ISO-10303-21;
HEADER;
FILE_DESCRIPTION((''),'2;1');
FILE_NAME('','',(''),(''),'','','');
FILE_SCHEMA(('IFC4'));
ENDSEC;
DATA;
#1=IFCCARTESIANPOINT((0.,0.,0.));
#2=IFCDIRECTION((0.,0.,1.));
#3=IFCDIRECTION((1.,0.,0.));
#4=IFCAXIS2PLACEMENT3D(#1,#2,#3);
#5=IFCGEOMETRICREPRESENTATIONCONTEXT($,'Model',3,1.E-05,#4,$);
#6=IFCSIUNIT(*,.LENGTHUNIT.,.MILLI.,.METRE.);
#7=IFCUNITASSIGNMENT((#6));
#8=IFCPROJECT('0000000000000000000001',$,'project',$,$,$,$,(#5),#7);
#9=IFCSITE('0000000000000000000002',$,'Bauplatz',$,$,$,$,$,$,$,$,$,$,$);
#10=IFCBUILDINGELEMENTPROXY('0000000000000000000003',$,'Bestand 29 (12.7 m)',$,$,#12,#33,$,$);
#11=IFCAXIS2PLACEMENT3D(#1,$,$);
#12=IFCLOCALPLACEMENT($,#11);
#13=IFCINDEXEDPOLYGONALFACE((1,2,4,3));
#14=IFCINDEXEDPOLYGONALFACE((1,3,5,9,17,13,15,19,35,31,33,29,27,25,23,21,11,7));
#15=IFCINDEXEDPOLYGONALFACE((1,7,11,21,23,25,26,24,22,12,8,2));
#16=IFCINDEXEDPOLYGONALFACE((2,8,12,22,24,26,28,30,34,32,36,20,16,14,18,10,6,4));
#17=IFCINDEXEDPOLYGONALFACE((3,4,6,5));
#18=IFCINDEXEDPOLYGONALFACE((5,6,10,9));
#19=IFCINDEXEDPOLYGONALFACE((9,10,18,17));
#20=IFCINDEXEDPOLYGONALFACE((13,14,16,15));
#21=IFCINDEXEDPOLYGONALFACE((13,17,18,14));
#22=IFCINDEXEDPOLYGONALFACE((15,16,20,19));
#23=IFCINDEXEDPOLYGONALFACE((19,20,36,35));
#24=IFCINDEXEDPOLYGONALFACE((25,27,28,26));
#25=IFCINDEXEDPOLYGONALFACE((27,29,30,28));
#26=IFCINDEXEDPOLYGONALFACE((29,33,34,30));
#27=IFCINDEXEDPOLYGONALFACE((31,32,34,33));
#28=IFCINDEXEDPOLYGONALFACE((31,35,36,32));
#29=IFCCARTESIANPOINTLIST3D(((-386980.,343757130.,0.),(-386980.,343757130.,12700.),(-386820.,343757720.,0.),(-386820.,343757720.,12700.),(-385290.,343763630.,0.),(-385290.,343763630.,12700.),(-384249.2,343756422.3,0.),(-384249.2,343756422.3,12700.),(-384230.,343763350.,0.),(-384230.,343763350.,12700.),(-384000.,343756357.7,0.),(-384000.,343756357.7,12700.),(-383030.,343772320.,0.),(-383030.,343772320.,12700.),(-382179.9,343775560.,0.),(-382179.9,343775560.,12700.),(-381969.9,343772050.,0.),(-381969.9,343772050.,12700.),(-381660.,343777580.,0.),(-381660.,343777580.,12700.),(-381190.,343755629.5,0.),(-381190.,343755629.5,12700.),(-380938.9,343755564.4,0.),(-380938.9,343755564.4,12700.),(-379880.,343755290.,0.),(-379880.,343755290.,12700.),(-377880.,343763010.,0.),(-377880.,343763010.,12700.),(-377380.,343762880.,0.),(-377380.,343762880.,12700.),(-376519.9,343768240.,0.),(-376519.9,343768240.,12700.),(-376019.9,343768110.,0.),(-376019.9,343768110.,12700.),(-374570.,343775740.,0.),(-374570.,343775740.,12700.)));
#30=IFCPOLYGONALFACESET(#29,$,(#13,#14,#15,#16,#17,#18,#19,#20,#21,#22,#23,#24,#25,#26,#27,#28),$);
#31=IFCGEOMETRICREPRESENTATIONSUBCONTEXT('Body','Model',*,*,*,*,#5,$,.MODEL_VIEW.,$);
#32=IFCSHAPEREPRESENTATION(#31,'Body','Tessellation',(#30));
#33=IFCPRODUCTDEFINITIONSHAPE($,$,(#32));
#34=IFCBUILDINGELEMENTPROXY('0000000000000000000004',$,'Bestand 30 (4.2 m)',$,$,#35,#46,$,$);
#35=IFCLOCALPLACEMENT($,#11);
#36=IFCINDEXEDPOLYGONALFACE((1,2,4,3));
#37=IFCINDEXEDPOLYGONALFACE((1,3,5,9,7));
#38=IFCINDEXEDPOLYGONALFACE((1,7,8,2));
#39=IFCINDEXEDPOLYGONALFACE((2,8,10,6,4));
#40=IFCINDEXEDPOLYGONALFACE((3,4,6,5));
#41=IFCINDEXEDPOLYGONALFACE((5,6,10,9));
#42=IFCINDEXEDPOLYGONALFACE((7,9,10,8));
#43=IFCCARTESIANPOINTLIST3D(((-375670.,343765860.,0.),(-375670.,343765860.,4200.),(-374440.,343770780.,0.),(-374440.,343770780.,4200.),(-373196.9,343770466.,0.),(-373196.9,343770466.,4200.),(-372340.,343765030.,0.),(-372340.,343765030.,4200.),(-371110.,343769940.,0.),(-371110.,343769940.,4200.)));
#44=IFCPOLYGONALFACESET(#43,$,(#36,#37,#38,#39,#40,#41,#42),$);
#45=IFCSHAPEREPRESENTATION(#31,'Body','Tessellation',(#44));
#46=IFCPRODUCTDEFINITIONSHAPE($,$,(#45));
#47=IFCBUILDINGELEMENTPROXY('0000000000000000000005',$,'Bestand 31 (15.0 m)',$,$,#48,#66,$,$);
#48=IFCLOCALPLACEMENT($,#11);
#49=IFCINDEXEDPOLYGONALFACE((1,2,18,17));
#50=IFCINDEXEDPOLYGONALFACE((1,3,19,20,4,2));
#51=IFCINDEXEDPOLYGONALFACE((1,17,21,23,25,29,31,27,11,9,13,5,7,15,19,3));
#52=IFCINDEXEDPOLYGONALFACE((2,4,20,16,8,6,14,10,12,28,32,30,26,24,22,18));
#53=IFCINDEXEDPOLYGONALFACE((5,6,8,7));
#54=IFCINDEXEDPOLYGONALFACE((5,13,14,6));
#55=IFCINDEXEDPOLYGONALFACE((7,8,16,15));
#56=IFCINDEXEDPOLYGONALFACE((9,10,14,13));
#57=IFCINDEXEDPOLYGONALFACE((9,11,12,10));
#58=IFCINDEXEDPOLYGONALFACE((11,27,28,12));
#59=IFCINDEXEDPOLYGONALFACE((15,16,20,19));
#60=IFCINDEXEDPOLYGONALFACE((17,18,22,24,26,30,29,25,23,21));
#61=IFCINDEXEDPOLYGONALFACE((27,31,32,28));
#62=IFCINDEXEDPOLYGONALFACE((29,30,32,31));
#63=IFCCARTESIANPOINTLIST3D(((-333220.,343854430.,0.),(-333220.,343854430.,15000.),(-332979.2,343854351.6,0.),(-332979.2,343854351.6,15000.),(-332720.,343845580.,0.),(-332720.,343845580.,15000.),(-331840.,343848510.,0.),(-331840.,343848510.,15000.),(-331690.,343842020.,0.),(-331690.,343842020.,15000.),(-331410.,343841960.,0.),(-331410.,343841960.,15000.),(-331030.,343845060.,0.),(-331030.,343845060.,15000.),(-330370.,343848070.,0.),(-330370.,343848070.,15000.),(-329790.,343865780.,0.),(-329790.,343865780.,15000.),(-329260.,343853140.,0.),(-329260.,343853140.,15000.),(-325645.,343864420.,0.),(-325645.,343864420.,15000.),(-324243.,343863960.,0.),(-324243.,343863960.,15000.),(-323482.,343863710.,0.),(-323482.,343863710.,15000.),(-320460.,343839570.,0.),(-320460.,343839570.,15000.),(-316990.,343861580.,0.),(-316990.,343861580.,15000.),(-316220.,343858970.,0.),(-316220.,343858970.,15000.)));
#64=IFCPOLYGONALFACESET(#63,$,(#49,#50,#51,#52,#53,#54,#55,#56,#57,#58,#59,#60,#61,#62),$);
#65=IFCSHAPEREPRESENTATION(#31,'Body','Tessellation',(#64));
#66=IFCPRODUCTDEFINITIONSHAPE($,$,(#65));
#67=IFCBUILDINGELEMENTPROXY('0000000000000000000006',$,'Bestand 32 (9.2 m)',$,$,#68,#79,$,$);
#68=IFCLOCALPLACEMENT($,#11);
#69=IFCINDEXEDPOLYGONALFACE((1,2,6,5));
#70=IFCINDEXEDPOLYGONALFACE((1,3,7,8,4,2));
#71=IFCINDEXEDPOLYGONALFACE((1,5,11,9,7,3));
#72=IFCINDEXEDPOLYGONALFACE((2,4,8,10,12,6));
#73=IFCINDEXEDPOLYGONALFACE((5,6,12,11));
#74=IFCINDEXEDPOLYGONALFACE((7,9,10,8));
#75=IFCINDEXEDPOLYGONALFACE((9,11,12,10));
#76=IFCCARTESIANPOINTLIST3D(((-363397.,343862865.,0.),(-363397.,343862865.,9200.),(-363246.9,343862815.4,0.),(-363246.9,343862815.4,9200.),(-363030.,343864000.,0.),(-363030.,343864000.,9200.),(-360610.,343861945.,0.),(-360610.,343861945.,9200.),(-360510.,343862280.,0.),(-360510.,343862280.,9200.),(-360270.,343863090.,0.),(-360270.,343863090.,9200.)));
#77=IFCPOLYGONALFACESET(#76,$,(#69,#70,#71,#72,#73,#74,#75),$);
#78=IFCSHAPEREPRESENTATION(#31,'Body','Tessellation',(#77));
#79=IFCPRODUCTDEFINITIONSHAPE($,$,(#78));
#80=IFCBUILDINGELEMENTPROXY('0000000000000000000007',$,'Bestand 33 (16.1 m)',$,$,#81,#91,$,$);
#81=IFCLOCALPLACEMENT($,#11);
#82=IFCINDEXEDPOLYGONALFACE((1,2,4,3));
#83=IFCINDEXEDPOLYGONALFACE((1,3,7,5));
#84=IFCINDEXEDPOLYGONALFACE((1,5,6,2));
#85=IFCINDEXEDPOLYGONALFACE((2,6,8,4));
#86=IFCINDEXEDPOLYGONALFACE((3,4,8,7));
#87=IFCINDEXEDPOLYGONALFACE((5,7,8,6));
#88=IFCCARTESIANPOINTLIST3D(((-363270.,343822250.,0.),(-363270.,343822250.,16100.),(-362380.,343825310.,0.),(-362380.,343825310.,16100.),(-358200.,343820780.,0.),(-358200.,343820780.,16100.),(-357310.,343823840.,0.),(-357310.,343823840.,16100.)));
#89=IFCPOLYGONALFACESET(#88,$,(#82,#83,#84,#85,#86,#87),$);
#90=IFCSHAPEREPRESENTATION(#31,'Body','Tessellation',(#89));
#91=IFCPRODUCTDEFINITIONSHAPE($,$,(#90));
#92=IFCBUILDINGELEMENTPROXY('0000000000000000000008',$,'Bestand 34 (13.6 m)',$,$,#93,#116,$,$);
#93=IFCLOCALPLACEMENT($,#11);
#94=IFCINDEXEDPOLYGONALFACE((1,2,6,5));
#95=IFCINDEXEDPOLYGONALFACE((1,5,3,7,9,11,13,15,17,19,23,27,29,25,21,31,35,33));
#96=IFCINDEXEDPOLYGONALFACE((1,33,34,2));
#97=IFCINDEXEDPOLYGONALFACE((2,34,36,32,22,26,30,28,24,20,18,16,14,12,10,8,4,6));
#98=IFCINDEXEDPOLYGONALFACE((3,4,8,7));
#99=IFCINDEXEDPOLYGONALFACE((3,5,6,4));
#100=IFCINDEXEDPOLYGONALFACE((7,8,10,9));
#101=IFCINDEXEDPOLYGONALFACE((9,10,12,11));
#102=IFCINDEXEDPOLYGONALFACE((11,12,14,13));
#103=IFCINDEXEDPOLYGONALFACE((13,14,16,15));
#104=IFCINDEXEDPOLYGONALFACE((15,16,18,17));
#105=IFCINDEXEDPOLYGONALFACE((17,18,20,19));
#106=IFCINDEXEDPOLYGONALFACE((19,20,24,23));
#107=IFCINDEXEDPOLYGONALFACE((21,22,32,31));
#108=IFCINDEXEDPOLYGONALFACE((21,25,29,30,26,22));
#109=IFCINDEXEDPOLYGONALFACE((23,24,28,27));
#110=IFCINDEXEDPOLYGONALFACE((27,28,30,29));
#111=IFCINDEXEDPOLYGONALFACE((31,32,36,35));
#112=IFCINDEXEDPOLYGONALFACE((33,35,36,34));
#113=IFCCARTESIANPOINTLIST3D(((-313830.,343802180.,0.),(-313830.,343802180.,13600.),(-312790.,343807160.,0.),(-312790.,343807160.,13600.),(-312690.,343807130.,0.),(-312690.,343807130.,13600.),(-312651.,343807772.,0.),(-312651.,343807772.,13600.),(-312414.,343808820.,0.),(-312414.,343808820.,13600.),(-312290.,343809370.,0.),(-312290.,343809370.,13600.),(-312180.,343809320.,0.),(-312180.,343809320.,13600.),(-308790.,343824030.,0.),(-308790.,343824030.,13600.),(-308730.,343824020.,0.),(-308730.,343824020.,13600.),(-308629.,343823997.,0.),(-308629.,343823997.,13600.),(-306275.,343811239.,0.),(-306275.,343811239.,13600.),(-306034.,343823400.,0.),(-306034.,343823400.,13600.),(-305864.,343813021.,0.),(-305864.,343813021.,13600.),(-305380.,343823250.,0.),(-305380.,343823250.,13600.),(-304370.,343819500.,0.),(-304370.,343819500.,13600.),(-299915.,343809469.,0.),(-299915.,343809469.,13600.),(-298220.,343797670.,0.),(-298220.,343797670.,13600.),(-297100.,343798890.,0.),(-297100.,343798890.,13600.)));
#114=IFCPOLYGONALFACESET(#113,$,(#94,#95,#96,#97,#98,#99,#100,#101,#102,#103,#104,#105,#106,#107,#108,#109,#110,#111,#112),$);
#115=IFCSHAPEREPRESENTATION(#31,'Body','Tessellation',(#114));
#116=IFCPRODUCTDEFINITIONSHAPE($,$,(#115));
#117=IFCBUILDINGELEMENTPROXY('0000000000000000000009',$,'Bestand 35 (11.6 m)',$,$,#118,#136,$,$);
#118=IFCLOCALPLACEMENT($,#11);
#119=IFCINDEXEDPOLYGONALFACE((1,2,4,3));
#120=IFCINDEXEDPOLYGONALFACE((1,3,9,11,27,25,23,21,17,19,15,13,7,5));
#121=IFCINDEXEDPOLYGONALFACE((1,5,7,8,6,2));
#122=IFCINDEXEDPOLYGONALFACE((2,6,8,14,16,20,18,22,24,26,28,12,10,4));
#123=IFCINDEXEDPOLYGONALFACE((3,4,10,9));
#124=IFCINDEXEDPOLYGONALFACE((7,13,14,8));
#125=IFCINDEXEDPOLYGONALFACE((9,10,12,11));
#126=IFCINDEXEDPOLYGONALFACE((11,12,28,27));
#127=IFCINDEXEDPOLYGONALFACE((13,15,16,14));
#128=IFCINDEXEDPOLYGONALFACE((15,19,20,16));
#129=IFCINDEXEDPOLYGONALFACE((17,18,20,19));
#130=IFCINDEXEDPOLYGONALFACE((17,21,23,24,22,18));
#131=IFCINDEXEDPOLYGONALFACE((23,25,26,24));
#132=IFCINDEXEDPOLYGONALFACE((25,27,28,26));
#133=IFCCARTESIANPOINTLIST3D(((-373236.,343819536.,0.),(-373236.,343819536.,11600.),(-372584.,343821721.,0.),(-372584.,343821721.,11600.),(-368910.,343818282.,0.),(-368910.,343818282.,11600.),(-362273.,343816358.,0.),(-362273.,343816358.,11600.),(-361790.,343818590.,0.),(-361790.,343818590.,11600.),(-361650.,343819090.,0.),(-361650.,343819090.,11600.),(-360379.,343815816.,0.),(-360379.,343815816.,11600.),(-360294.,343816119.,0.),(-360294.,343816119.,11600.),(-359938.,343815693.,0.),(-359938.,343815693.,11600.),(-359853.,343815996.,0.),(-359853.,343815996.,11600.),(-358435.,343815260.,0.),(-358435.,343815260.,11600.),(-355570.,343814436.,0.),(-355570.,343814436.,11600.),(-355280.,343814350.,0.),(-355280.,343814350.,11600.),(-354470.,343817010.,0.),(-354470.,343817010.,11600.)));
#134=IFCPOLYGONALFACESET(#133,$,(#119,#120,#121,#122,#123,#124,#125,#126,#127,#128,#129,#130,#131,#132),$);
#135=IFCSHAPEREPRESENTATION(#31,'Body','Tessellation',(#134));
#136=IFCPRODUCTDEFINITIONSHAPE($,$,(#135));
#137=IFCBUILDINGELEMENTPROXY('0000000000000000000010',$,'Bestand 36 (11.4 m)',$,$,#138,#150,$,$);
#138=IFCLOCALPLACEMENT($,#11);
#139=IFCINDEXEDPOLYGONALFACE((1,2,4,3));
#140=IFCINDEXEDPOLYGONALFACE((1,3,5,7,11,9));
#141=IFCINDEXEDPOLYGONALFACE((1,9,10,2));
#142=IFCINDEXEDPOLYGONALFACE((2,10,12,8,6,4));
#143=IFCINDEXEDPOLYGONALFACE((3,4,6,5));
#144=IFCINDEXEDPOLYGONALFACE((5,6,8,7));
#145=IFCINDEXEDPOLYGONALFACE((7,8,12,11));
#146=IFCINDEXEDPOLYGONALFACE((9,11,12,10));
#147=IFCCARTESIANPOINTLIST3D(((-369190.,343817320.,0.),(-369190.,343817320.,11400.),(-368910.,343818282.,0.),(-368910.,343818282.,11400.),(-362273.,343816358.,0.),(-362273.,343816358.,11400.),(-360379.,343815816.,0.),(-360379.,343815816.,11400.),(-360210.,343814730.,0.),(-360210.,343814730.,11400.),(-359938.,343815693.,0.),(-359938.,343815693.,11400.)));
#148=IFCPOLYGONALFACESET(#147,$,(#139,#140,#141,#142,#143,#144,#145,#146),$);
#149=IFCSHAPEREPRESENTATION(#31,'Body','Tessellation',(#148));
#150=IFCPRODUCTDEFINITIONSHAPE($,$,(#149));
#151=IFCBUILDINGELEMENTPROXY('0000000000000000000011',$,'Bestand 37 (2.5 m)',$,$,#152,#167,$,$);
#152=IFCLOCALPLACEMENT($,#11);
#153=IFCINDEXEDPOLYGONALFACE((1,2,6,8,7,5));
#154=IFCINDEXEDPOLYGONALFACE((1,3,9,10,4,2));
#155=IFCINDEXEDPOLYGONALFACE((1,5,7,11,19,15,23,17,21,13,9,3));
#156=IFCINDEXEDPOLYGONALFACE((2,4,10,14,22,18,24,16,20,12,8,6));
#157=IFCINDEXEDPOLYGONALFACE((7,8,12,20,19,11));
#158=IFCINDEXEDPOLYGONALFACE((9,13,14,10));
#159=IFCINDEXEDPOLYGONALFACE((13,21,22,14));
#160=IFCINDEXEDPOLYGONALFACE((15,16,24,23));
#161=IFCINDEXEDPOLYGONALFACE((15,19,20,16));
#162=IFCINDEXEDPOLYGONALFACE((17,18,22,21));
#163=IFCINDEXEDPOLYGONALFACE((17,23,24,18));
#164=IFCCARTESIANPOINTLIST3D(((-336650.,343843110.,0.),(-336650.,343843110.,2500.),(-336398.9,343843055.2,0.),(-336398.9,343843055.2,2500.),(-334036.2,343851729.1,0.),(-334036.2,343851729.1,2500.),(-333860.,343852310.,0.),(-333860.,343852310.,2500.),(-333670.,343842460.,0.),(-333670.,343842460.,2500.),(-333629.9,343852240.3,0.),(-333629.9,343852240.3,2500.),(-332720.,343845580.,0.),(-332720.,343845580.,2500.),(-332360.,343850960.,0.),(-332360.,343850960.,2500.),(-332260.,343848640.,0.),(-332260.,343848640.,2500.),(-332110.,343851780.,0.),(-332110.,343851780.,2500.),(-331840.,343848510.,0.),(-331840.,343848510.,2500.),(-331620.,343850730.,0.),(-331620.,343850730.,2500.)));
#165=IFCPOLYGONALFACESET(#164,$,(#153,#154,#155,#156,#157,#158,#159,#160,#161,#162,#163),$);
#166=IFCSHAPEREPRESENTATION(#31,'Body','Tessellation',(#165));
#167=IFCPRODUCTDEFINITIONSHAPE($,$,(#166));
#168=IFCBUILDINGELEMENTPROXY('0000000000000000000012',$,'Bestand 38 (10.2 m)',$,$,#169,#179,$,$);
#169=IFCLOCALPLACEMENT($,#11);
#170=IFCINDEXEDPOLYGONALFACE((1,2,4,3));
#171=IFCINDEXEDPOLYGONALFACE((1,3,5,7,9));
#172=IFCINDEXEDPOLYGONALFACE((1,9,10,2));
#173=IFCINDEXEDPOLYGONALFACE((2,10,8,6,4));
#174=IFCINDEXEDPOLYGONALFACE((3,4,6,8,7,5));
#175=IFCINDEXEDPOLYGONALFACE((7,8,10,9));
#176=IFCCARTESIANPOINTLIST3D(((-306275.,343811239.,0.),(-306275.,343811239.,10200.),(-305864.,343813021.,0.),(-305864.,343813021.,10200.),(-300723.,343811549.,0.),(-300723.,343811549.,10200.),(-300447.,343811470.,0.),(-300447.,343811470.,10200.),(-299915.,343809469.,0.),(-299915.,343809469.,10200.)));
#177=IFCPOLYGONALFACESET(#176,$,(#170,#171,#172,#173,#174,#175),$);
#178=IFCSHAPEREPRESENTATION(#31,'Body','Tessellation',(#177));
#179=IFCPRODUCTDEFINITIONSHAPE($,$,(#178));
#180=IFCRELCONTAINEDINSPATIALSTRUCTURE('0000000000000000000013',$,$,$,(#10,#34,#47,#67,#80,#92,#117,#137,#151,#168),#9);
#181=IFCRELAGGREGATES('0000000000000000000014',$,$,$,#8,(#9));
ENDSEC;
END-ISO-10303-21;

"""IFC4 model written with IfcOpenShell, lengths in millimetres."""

from ifc_helpers import new_model, si_unit, origin_with_axes, place, context, subcontext, project, spatial, indexed_curve, outline, extrude, element, save


model = new_model("IFC4")

# Units and contexts
model_context = context("Model", 3, precision=1e-05, world=origin_with_axes())
body_context = subcontext(model_context, "Body", "Model", "MODEL_VIEW")
ifc_project = project(units=[si_unit("LENGTHUNIT", "METRE", prefix="MILLI")], contexts=[model_context])

# Site
site = spatial("IfcSite", under=ifc_project, Name="Bauplatz")

# Building element proxies
proxy_1_placement = place(None, origin_with_axes())
element("IfcBuildingElementProxy", 1, at=proxy_1_placement, inside=site, Name="Bestand 29 (12.7 m)", context=body_context, shape_type="SweptSolid", body=[
    extrude(outline(indexed_curve([(-374570.0, 343775740.0), (-381660.0, 343777580.0), (-382179.9, 343775560.0), (-383030.0, 343772320.0), (-381969.9, 343772050.0), (-384230.0, 343763350.0), (-385290.0, 343763630.0), (-386820.0, 343757720.0), (-386980.0, 343757130.0), (-384249.2, 343756422.3), (-384000.0, 343756357.7), (-381190.0, 343755629.5), (-380938.9, 343755564.4), (-379880.0, 343755290.0), (-377880.0, 343763010.0), (-377380.0, 343762880.0), (-376019.9, 343768110.0), (-376519.9, 343768240.0)])), None, (0.0, 0.0, 1.0), 12700.0),
])
proxy_2_placement = place(None, origin_with_axes())
element("IfcBuildingElementProxy", 2, at=proxy_2_placement, inside=site, Name="Bestand 30 (4.2 m)", context=body_context, shape_type="SweptSolid", body=[
    extrude(outline(indexed_curve([(-373196.9, 343770466.0), (-374440.0, 343770780.0), (-375670.0, 343765860.0), (-372340.0, 343765030.0), (-371110.0, 343769940.0)])), None, (0.0, 0.0, 1.0), 4200.0),
])
proxy_3_placement = place(None, origin_with_axes())
element("IfcBuildingElementProxy", 3, at=proxy_3_placement, inside=site, Name="Bestand 31 (15.0 m)", context=body_context, shape_type="SweptSolid", body=[
    extrude(outline(indexed_curve([(-325645.0, 343864420.0), (-329790.0, 343865780.0), (-333220.0, 343854430.0), (-332979.2, 343854351.6), (-329260.0, 343853140.0), (-330370.0, 343848070.0), (-331840.0, 343848510.0), (-332720.0, 343845580.0), (-331030.0, 343845060.0), (-331690.0, 343842020.0), (-331410.0, 343841960.0), (-320460.0, 343839570.0), (-316220.0, 343858970.0), (-316990.0, 343861580.0), (-323482.0, 343863710.0), (-324243.0, 343863960.0)])), None, (0.0, 0.0, 1.0), 15000.0),
])
proxy_4_placement = place(None, origin_with_axes())
element("IfcBuildingElementProxy", 4, at=proxy_4_placement, inside=site, Name="Bestand 32 (9.2 m)", context=body_context, shape_type="SweptSolid", body=[
    extrude(outline(indexed_curve([(-360270.0, 343863090.0), (-363030.0, 343864000.0), (-363397.0, 343862865.0), (-363246.9, 343862815.4), (-360610.0, 343861945.0), (-360510.0, 343862280.0)])), None, (0.0, 0.0, 1.0), 9200.0),
])
proxy_5_placement = place(None, origin_with_axes())
element("IfcBuildingElementProxy", 5, at=proxy_5_placement, inside=site, Name="Bestand 33 (16.1 m)", context=body_context, shape_type="SweptSolid", body=[
    extrude(outline(indexed_curve([(-357310.0, 343823840.0), (-362380.0, 343825310.0), (-363270.0, 343822250.0), (-358200.0, 343820780.0)])), None, (0.0, 0.0, 1.0), 16100.0),
])
proxy_6_placement = place(None, origin_with_axes())
element("IfcBuildingElementProxy", 6, at=proxy_6_placement, inside=site, Name="Bestand 34 (13.6 m)", context=body_context, shape_type="SweptSolid", body=[
    extrude(outline(indexed_curve([(-308730.0, 343824020.0), (-308790.0, 343824030.0), (-312180.0, 343809320.0), (-312290.0, 343809370.0), (-312414.0, 343808820.0), (-312651.0, 343807772.0), (-312790.0, 343807160.0), (-312690.0, 343807130.0), (-313830.0, 343802180.0), (-298220.0, 343797670.0), (-297100.0, 343798890.0), (-299915.0, 343809469.0), (-306275.0, 343811239.0), (-305864.0, 343813021.0), (-304370.0, 343819500.0), (-305380.0, 343823250.0), (-306034.0, 343823400.0), (-308629.0, 343823997.0)])), None, (0.0, 0.0, 1.0), 13600.0),
])
proxy_7_placement = place(None, origin_with_axes())
element("IfcBuildingElementProxy", 7, at=proxy_7_placement, inside=site, Name="Bestand 35 (11.6 m)", context=body_context, shape_type="SweptSolid", body=[
    extrude(outline(indexed_curve([(-361790.0, 343818590.0), (-372584.0, 343821721.0), (-373236.0, 343819536.0), (-368910.0, 343818282.0), (-362273.0, 343816358.0), (-360379.0, 343815816.0), (-360294.0, 343816119.0), (-359853.0, 343815996.0), (-359938.0, 343815693.0), (-358435.0, 343815260.0), (-355570.0, 343814436.0), (-355280.0, 343814350.0), (-354470.0, 343817010.0), (-361650.0, 343819090.0)])), None, (0.0, 0.0, 1.0), 11600.0),
])
proxy_8_placement = place(None, origin_with_axes())
element("IfcBuildingElementProxy", 8, at=proxy_8_placement, inside=site, Name="Bestand 36 (11.4 m)", context=body_context, shape_type="SweptSolid", body=[
    extrude(outline(indexed_curve([(-362273.0, 343816358.0), (-368910.0, 343818282.0), (-369190.0, 343817320.0), (-360210.0, 343814730.0), (-359938.0, 343815693.0), (-360379.0, 343815816.0)])), None, (0.0, 0.0, 1.0), 11400.0),
])
proxy_9_placement = place(None, origin_with_axes())
element("IfcBuildingElementProxy", 9, at=proxy_9_placement, inside=site, Name="Bestand 37 (2.5 m)", context=body_context, shape_type="SweptSolid", body=[
    extrude(outline(indexed_curve([(-333629.9, 343852240.3), (-333860.0, 343852310.0), (-334036.2, 343851729.1), (-336650.0, 343843110.0), (-336398.9, 343843055.2), (-333670.0, 343842460.0), (-332720.0, 343845580.0), (-331840.0, 343848510.0), (-332260.0, 343848640.0), (-331620.0, 343850730.0), (-332360.0, 343850960.0), (-332110.0, 343851780.0)])), None, (0.0, 0.0, 1.0), 2500.0),
])
proxy_10_placement = place(None, origin_with_axes())
element("IfcBuildingElementProxy", 10, at=proxy_10_placement, inside=site, Name="Bestand 38 (10.2 m)", context=body_context, shape_type="SweptSolid", body=[
    extrude(outline(indexed_curve([(-300723.0, 343811549.0), (-305864.0, 343813021.0), (-306275.0, 343811239.0), (-299915.0, 343809469.0), (-300447.0, 343811470.0)])), None, (0.0, 0.0, 1.0), 10200.0),
])

save(model, "model.ifc")
